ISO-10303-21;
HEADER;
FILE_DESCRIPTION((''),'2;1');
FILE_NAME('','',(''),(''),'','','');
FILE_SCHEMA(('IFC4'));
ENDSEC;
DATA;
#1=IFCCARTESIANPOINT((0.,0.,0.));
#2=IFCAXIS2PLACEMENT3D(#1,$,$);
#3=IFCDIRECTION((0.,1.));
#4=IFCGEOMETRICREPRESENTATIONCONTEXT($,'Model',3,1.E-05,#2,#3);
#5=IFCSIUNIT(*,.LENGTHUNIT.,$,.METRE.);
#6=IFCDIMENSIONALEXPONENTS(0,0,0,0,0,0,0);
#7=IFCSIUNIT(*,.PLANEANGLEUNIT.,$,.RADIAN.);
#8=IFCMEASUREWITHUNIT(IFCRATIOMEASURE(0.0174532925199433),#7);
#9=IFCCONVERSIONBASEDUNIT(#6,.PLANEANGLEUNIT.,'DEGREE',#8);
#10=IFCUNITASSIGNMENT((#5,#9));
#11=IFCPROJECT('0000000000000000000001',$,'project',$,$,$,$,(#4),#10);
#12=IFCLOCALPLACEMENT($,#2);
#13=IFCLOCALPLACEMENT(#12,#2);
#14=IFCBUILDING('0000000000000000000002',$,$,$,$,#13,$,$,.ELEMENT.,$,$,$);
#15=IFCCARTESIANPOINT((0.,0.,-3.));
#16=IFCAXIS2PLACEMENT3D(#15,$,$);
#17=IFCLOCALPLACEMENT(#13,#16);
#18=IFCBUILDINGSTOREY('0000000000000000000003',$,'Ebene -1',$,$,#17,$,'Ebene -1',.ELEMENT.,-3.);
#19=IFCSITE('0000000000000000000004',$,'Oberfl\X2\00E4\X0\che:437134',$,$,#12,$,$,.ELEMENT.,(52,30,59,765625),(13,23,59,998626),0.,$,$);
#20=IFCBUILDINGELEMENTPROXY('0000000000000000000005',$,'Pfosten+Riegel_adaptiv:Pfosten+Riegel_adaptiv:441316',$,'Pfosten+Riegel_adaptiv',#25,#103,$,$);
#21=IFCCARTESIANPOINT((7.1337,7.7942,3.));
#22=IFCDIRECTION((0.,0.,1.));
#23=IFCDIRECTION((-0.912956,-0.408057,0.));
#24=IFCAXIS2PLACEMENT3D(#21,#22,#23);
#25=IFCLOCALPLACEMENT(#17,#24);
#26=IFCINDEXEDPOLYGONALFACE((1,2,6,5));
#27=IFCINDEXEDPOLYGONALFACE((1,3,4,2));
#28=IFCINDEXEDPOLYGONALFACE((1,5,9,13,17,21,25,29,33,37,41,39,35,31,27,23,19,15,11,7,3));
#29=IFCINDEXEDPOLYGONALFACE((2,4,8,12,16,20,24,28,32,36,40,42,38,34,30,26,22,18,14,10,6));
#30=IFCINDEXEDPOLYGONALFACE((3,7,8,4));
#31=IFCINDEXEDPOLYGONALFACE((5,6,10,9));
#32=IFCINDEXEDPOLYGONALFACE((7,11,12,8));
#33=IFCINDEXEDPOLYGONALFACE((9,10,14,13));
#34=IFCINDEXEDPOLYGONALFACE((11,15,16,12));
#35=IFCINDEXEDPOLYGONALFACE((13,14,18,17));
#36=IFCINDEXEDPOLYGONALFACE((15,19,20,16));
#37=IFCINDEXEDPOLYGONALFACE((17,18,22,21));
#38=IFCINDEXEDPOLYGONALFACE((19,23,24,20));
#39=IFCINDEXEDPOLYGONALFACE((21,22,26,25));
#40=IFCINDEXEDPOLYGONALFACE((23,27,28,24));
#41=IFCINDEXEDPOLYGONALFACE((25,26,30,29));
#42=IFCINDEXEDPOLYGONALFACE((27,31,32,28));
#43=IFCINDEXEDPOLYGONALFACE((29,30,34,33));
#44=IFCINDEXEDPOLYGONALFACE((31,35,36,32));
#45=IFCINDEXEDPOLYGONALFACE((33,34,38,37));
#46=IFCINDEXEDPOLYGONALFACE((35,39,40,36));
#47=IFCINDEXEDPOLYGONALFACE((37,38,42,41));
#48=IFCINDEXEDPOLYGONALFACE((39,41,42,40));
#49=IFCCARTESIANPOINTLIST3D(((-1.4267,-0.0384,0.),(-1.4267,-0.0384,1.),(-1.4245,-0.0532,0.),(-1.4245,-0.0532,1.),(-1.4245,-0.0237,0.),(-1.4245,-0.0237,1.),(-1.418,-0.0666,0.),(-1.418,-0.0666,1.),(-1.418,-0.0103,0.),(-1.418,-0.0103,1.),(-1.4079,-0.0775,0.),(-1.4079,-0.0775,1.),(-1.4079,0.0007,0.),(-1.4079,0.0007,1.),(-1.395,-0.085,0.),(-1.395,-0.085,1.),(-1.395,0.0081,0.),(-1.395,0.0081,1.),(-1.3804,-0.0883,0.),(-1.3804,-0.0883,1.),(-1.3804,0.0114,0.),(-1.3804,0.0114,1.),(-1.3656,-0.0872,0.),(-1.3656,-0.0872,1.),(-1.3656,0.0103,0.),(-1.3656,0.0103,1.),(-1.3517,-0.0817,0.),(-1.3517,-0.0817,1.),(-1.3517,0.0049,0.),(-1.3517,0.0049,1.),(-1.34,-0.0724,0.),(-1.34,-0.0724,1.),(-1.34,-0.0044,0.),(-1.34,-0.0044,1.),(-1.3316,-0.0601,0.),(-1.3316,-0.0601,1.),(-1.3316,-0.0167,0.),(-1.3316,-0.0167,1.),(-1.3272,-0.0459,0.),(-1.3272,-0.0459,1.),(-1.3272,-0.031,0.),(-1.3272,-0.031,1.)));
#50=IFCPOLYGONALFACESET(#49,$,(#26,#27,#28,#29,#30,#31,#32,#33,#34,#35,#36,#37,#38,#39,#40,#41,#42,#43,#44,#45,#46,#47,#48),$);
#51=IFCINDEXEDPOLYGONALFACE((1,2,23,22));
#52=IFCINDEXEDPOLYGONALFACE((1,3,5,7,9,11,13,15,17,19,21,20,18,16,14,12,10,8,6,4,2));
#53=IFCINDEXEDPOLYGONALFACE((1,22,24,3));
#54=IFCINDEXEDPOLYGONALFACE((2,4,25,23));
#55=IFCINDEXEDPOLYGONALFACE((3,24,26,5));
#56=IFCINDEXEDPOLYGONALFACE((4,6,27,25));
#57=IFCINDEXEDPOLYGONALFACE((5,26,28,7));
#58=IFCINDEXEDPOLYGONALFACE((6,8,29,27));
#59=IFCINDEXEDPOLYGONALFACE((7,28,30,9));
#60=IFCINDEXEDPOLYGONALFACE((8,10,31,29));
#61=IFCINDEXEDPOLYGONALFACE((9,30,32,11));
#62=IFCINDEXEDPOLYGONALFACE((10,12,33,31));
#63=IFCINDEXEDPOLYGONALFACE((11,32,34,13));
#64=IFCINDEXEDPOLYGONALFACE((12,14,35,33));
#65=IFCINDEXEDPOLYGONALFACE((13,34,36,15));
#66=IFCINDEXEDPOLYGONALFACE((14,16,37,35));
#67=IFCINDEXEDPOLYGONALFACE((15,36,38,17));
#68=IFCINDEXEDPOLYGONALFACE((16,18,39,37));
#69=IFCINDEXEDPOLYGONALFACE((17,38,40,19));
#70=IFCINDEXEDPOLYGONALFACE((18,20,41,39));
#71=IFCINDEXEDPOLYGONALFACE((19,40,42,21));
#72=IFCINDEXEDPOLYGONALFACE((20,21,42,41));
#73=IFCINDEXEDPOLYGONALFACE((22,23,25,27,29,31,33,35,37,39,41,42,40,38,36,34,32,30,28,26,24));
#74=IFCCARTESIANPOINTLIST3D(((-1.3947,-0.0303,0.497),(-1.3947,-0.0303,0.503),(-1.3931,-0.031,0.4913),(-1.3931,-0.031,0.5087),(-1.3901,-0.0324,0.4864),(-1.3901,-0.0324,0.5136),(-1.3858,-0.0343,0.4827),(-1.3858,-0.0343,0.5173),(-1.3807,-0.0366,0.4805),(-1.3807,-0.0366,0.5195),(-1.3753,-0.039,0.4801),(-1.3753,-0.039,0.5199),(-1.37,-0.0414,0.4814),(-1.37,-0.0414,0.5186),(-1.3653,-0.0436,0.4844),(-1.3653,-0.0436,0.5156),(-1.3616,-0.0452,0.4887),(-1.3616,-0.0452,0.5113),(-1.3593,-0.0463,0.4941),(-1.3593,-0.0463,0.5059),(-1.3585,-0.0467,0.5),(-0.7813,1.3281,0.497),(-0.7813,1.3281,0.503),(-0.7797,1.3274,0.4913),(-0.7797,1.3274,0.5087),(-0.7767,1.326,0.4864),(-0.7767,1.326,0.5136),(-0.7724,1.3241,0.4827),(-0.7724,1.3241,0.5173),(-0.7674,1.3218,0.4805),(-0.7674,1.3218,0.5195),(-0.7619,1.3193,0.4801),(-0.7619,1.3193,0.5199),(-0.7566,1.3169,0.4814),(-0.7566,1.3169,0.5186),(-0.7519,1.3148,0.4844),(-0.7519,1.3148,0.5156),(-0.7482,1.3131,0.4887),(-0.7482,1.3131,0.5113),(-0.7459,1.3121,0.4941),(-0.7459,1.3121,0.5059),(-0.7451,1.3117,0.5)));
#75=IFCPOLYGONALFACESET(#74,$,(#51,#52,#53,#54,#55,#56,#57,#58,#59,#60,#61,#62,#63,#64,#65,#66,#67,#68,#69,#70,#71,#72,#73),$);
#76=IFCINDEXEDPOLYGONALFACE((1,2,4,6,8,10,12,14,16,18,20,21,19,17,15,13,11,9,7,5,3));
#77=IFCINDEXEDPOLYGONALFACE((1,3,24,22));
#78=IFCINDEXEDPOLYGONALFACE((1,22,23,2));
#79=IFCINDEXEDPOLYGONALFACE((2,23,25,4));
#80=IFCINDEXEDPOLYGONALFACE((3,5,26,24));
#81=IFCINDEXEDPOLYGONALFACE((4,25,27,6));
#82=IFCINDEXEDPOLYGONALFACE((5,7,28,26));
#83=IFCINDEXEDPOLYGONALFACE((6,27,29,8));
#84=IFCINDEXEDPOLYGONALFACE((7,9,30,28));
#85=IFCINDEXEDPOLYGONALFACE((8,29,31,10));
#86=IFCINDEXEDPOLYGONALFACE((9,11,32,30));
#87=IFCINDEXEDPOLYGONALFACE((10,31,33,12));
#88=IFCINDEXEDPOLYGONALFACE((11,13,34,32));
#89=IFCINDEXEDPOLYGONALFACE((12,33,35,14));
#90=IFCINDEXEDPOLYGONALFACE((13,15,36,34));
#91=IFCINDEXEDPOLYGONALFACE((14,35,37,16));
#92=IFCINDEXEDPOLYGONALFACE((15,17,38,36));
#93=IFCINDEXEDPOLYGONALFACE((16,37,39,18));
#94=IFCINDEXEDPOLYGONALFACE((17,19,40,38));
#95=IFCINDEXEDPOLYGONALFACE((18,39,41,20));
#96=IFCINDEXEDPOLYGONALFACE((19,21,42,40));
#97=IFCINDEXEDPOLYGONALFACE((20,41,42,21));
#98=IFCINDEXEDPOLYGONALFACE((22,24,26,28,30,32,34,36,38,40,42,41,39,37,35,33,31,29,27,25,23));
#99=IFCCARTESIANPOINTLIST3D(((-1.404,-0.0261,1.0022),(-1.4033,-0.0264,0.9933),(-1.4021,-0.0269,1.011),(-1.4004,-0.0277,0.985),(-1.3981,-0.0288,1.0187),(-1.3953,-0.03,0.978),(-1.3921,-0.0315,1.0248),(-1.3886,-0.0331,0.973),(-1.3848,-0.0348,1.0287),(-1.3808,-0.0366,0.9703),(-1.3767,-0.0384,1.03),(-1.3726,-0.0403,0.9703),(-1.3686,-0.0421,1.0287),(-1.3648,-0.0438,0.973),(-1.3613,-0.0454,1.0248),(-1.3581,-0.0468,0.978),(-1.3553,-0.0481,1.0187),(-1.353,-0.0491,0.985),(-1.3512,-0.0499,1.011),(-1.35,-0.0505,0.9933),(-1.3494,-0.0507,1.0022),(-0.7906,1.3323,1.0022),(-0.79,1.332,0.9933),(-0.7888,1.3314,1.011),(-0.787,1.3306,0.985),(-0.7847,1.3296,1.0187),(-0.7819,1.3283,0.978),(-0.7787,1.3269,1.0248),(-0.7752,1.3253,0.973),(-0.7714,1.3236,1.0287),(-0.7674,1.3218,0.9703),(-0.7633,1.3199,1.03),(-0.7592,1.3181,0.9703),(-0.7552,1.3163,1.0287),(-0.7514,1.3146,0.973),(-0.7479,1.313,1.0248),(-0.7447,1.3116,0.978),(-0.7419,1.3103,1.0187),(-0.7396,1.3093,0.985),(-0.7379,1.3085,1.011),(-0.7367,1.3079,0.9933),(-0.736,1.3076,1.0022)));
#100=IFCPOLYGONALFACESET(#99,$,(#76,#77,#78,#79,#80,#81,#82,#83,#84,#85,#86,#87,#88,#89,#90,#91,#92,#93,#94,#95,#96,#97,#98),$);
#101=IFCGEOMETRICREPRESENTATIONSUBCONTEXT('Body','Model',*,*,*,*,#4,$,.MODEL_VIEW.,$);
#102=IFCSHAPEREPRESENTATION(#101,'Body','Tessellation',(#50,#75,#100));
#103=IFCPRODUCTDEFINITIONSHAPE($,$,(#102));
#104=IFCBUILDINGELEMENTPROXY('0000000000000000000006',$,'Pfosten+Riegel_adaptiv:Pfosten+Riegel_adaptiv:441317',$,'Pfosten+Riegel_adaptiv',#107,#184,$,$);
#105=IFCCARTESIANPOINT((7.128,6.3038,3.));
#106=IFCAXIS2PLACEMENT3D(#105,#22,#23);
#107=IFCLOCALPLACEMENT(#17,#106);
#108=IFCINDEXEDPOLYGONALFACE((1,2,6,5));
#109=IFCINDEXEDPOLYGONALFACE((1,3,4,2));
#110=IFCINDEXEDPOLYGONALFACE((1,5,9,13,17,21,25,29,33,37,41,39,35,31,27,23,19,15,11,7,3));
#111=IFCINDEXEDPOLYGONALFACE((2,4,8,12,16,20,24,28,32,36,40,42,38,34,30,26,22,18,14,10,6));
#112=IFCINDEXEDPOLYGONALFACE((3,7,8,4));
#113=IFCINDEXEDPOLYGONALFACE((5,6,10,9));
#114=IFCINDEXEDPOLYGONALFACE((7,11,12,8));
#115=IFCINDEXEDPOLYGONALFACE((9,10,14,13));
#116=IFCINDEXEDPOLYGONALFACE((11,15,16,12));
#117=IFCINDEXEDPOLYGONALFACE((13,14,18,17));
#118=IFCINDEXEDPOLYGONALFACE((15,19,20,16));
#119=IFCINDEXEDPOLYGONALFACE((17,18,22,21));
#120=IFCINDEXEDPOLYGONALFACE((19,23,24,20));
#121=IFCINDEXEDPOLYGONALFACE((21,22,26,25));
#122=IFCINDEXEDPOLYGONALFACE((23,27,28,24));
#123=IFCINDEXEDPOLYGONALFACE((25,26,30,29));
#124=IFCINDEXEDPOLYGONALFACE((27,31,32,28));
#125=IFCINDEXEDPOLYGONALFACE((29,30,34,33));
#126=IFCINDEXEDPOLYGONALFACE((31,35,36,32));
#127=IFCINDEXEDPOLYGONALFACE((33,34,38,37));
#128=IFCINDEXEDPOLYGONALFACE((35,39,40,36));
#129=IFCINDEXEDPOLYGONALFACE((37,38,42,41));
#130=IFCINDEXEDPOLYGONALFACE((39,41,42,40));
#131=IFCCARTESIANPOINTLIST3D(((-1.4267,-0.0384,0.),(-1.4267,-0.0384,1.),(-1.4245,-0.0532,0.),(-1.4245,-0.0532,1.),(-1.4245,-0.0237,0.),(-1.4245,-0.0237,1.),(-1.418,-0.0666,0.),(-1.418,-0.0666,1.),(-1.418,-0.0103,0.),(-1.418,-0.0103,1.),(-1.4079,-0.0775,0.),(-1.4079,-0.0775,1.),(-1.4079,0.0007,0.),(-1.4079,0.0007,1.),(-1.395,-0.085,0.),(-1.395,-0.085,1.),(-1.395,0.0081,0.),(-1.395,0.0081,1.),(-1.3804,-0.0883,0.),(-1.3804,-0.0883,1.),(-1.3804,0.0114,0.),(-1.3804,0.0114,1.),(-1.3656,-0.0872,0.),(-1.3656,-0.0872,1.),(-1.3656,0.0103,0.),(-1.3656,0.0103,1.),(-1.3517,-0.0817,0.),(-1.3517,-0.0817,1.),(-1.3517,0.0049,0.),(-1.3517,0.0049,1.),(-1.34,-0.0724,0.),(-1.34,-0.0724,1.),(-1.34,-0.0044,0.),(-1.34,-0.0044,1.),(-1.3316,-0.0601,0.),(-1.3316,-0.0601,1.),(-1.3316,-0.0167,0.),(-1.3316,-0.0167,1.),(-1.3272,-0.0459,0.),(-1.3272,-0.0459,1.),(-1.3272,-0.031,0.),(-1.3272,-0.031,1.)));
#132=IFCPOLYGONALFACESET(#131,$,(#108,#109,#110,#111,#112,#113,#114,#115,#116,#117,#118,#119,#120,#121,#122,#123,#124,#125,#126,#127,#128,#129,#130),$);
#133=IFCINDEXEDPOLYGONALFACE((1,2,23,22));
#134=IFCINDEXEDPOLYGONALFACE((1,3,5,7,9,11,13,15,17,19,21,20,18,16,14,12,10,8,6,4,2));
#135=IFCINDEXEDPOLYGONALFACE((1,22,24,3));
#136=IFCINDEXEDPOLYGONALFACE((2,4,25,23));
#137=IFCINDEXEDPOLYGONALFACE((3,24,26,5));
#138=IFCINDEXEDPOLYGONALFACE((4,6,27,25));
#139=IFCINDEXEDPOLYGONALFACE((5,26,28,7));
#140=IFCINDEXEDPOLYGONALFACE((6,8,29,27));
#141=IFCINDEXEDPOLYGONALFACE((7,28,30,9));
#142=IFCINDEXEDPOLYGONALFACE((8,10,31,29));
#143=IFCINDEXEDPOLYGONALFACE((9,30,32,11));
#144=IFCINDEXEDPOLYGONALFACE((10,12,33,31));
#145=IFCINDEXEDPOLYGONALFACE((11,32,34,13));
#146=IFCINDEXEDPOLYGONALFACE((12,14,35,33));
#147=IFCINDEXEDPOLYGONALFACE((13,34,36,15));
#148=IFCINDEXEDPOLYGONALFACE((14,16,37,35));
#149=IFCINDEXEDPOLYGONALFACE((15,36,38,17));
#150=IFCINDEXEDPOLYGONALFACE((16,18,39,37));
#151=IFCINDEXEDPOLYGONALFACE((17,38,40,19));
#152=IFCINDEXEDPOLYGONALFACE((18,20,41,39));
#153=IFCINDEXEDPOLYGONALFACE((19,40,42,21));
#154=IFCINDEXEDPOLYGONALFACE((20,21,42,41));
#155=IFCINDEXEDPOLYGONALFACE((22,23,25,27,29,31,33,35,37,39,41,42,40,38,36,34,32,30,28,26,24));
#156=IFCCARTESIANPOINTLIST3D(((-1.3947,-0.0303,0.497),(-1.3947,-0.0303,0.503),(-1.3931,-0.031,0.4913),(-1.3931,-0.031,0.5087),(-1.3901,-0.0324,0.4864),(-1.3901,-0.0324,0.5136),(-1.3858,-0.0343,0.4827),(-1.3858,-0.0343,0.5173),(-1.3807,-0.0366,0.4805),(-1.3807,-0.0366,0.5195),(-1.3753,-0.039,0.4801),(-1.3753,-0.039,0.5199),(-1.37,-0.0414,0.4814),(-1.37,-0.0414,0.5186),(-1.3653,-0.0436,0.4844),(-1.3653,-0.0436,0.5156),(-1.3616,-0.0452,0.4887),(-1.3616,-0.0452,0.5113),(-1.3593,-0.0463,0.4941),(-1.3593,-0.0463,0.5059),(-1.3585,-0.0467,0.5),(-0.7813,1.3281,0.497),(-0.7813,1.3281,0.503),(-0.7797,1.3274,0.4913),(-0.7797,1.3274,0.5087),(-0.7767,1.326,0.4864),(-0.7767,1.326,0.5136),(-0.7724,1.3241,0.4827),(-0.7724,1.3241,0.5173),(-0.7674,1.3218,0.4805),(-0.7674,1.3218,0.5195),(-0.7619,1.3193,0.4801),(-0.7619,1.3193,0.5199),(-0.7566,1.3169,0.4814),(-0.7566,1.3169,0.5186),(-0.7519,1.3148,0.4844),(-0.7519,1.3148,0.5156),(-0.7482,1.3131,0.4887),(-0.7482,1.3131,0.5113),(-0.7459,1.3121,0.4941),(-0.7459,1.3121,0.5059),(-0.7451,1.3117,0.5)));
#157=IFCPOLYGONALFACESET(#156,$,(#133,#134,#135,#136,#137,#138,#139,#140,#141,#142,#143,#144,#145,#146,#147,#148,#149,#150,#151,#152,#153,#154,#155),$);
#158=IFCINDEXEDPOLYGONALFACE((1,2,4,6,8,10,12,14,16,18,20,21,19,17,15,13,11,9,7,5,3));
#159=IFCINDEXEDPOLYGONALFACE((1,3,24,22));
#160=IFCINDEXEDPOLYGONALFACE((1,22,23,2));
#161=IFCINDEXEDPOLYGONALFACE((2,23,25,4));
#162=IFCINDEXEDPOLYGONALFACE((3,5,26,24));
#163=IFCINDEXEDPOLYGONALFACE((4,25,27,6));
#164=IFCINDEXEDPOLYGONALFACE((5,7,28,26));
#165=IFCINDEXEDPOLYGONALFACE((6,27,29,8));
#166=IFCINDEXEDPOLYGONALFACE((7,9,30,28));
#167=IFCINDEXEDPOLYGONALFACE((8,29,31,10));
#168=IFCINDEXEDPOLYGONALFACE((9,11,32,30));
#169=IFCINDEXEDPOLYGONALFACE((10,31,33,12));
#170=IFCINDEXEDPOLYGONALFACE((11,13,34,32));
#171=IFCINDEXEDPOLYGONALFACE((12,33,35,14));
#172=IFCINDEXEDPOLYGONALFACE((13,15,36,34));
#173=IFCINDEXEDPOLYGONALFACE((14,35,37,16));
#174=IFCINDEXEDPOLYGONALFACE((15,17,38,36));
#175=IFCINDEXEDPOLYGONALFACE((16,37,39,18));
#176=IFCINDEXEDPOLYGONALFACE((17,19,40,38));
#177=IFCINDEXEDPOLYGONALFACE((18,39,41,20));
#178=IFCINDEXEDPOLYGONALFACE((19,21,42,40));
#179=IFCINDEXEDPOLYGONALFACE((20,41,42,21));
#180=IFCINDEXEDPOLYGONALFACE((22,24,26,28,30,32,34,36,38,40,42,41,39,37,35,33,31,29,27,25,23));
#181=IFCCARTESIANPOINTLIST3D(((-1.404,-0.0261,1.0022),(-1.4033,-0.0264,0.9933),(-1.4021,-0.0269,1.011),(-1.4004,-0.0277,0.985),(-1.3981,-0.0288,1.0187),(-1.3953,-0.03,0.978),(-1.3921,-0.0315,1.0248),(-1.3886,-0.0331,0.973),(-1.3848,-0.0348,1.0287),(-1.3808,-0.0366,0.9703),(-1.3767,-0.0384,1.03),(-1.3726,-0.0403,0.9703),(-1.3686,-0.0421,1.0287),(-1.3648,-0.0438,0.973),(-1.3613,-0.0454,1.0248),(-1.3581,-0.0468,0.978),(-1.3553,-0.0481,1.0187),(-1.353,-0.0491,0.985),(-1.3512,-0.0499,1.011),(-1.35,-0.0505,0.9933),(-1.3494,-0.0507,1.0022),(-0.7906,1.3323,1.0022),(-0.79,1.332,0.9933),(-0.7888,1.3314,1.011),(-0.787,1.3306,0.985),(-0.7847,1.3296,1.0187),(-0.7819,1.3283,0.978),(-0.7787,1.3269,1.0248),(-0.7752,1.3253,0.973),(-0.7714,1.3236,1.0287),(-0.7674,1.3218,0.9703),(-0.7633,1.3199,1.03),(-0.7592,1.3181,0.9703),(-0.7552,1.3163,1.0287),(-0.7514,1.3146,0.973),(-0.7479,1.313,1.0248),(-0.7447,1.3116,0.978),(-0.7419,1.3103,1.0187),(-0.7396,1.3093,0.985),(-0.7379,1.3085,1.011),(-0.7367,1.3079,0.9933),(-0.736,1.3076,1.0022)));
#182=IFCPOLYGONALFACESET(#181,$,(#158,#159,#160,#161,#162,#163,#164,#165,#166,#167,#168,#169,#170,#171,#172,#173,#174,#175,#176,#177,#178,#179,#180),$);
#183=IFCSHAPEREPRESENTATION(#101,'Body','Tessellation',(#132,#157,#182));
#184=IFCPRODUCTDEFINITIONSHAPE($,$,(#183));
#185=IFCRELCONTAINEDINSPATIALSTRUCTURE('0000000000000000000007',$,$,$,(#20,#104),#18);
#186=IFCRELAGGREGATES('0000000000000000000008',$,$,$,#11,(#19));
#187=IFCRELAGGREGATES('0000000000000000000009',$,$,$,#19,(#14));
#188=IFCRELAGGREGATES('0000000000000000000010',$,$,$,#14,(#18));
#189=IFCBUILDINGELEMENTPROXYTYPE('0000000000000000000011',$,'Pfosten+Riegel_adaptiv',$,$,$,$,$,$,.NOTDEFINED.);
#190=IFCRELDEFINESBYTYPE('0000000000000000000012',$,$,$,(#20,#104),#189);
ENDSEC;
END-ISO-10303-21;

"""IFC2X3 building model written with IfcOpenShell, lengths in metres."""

from ifc_helpers import new_model, entity, si_unit, converted_unit, direction, frame, frame_2d, origin, place, context, subcontext, project, spatial, circle, extrude, source, transform, mapped, type_object, type_shapes, element, save


model = new_model("IFC2X3")

# Units and contexts
model_context = context("Model", 3, precision=1e-05, world=origin(), true_north=direction((0.0, 1.0)))
body_context = subcontext(model_context, "Body", "Model", "MODEL_VIEW")
ifc_project = project(units=[si_unit("LENGTHUNIT", "METRE"), converted_unit("PLANEANGLEUNIT", "DEGREE", entity("IfcRatioMeasure", 0.0174532925199433), si_unit("PLANEANGLEUNIT", "RADIAN"), dimensions=[0, 0, 0, 0, 0, 0, 0])], contexts=[model_context])

# Site, building, storey
site_placement = place(None, origin())
site = spatial("IfcSite", under=ifc_project, at=site_placement, Name="Oberfläche:437134", CompositionType="ELEMENT", RefLatitude=(52, 30, 59, 765625), RefLongitude=(13, 23, 59, 998626), RefElevation=0.0)
building_placement = place(site_placement, origin())
building = spatial("IfcBuilding", under=site, at=building_placement, CompositionType="ELEMENT")
storey_placement = place(building_placement, frame((0.0, 0.0, -3.0)))
storey = spatial("IfcBuildingStorey", under=building, at=storey_placement, Name="Ebene -1", LongName="Ebene -1", CompositionType="ELEMENT", Elevation=-3.0)

# Building element proxies
building_element_proxy_type_1 = type_object("IfcBuildingElementProxyType", Name="Pfosten+Riegel_adaptiv", PredefinedType="NOTDEFINED")
shared_shape_1 = source(origin(), body_context, "Body", "SweptSolid", [
    extrude(circle(Radius=0.05, at=frame_2d((0.0, 0.0), x_axis=(1.0, 0.0))), frame((-1.3767, -0.0384, 0.0), z_axis=(0.0, 0.0, 1.0), x_axis=(-1.0, 0.0, 0.0)), (0.0, 0.0, 1.0), 1.0),
    extrude(circle(Radius=0.02, at=frame_2d((0.0, 0.0), x_axis=(1.0, 0.0))), frame((-1.3767, -0.0384, 0.5), z_axis=(0.411546, 0.911389, 0.0), x_axis=(0.911389, -0.411546, 0.0)), (0.0, 0.0, 1.0), 1.4904),
    extrude(circle(Radius=0.03, at=frame_2d((0.0, 0.0), x_axis=(1.0, 0.0))), frame((-1.3767, -0.0384, 1.0), z_axis=(0.411546, 0.911389, 0.0), x_axis=(0.0, 0.0, 1.0)), (0.0, 0.0, 1.0), 1.4904),
])
type_shapes(building_element_proxy_type_1, [shared_shape_1])
for number, where, z_axis, x_axis, name in (
    (1, (7.1337, 7.7942, 3.0), (0.0, 0.0, 1.0), (-0.912956, -0.408057, 0.0), "Pfosten+Riegel_adaptiv:Pfosten+Riegel_adaptiv:441316"),
    (2, (7.128, 6.3038, 3.0), (0.0, 0.0, 1.0), (-0.912956, -0.408057, 0.0), "Pfosten+Riegel_adaptiv:Pfosten+Riegel_adaptiv:441317"),
):
    element("IfcBuildingElementProxy", number, at=place(storey_placement, frame(where, z_axis=z_axis, x_axis=x_axis)), inside=storey, type_object=building_element_proxy_type_1, Name=name, ObjectType="Pfosten+Riegel_adaptiv", context=body_context, shape_type="MappedRepresentation", body=[
        mapped(shared_shape_1, transform((0.0, 0.0, 0.0), scale=1.0)),
    ])

save(model, "model.ifc")
